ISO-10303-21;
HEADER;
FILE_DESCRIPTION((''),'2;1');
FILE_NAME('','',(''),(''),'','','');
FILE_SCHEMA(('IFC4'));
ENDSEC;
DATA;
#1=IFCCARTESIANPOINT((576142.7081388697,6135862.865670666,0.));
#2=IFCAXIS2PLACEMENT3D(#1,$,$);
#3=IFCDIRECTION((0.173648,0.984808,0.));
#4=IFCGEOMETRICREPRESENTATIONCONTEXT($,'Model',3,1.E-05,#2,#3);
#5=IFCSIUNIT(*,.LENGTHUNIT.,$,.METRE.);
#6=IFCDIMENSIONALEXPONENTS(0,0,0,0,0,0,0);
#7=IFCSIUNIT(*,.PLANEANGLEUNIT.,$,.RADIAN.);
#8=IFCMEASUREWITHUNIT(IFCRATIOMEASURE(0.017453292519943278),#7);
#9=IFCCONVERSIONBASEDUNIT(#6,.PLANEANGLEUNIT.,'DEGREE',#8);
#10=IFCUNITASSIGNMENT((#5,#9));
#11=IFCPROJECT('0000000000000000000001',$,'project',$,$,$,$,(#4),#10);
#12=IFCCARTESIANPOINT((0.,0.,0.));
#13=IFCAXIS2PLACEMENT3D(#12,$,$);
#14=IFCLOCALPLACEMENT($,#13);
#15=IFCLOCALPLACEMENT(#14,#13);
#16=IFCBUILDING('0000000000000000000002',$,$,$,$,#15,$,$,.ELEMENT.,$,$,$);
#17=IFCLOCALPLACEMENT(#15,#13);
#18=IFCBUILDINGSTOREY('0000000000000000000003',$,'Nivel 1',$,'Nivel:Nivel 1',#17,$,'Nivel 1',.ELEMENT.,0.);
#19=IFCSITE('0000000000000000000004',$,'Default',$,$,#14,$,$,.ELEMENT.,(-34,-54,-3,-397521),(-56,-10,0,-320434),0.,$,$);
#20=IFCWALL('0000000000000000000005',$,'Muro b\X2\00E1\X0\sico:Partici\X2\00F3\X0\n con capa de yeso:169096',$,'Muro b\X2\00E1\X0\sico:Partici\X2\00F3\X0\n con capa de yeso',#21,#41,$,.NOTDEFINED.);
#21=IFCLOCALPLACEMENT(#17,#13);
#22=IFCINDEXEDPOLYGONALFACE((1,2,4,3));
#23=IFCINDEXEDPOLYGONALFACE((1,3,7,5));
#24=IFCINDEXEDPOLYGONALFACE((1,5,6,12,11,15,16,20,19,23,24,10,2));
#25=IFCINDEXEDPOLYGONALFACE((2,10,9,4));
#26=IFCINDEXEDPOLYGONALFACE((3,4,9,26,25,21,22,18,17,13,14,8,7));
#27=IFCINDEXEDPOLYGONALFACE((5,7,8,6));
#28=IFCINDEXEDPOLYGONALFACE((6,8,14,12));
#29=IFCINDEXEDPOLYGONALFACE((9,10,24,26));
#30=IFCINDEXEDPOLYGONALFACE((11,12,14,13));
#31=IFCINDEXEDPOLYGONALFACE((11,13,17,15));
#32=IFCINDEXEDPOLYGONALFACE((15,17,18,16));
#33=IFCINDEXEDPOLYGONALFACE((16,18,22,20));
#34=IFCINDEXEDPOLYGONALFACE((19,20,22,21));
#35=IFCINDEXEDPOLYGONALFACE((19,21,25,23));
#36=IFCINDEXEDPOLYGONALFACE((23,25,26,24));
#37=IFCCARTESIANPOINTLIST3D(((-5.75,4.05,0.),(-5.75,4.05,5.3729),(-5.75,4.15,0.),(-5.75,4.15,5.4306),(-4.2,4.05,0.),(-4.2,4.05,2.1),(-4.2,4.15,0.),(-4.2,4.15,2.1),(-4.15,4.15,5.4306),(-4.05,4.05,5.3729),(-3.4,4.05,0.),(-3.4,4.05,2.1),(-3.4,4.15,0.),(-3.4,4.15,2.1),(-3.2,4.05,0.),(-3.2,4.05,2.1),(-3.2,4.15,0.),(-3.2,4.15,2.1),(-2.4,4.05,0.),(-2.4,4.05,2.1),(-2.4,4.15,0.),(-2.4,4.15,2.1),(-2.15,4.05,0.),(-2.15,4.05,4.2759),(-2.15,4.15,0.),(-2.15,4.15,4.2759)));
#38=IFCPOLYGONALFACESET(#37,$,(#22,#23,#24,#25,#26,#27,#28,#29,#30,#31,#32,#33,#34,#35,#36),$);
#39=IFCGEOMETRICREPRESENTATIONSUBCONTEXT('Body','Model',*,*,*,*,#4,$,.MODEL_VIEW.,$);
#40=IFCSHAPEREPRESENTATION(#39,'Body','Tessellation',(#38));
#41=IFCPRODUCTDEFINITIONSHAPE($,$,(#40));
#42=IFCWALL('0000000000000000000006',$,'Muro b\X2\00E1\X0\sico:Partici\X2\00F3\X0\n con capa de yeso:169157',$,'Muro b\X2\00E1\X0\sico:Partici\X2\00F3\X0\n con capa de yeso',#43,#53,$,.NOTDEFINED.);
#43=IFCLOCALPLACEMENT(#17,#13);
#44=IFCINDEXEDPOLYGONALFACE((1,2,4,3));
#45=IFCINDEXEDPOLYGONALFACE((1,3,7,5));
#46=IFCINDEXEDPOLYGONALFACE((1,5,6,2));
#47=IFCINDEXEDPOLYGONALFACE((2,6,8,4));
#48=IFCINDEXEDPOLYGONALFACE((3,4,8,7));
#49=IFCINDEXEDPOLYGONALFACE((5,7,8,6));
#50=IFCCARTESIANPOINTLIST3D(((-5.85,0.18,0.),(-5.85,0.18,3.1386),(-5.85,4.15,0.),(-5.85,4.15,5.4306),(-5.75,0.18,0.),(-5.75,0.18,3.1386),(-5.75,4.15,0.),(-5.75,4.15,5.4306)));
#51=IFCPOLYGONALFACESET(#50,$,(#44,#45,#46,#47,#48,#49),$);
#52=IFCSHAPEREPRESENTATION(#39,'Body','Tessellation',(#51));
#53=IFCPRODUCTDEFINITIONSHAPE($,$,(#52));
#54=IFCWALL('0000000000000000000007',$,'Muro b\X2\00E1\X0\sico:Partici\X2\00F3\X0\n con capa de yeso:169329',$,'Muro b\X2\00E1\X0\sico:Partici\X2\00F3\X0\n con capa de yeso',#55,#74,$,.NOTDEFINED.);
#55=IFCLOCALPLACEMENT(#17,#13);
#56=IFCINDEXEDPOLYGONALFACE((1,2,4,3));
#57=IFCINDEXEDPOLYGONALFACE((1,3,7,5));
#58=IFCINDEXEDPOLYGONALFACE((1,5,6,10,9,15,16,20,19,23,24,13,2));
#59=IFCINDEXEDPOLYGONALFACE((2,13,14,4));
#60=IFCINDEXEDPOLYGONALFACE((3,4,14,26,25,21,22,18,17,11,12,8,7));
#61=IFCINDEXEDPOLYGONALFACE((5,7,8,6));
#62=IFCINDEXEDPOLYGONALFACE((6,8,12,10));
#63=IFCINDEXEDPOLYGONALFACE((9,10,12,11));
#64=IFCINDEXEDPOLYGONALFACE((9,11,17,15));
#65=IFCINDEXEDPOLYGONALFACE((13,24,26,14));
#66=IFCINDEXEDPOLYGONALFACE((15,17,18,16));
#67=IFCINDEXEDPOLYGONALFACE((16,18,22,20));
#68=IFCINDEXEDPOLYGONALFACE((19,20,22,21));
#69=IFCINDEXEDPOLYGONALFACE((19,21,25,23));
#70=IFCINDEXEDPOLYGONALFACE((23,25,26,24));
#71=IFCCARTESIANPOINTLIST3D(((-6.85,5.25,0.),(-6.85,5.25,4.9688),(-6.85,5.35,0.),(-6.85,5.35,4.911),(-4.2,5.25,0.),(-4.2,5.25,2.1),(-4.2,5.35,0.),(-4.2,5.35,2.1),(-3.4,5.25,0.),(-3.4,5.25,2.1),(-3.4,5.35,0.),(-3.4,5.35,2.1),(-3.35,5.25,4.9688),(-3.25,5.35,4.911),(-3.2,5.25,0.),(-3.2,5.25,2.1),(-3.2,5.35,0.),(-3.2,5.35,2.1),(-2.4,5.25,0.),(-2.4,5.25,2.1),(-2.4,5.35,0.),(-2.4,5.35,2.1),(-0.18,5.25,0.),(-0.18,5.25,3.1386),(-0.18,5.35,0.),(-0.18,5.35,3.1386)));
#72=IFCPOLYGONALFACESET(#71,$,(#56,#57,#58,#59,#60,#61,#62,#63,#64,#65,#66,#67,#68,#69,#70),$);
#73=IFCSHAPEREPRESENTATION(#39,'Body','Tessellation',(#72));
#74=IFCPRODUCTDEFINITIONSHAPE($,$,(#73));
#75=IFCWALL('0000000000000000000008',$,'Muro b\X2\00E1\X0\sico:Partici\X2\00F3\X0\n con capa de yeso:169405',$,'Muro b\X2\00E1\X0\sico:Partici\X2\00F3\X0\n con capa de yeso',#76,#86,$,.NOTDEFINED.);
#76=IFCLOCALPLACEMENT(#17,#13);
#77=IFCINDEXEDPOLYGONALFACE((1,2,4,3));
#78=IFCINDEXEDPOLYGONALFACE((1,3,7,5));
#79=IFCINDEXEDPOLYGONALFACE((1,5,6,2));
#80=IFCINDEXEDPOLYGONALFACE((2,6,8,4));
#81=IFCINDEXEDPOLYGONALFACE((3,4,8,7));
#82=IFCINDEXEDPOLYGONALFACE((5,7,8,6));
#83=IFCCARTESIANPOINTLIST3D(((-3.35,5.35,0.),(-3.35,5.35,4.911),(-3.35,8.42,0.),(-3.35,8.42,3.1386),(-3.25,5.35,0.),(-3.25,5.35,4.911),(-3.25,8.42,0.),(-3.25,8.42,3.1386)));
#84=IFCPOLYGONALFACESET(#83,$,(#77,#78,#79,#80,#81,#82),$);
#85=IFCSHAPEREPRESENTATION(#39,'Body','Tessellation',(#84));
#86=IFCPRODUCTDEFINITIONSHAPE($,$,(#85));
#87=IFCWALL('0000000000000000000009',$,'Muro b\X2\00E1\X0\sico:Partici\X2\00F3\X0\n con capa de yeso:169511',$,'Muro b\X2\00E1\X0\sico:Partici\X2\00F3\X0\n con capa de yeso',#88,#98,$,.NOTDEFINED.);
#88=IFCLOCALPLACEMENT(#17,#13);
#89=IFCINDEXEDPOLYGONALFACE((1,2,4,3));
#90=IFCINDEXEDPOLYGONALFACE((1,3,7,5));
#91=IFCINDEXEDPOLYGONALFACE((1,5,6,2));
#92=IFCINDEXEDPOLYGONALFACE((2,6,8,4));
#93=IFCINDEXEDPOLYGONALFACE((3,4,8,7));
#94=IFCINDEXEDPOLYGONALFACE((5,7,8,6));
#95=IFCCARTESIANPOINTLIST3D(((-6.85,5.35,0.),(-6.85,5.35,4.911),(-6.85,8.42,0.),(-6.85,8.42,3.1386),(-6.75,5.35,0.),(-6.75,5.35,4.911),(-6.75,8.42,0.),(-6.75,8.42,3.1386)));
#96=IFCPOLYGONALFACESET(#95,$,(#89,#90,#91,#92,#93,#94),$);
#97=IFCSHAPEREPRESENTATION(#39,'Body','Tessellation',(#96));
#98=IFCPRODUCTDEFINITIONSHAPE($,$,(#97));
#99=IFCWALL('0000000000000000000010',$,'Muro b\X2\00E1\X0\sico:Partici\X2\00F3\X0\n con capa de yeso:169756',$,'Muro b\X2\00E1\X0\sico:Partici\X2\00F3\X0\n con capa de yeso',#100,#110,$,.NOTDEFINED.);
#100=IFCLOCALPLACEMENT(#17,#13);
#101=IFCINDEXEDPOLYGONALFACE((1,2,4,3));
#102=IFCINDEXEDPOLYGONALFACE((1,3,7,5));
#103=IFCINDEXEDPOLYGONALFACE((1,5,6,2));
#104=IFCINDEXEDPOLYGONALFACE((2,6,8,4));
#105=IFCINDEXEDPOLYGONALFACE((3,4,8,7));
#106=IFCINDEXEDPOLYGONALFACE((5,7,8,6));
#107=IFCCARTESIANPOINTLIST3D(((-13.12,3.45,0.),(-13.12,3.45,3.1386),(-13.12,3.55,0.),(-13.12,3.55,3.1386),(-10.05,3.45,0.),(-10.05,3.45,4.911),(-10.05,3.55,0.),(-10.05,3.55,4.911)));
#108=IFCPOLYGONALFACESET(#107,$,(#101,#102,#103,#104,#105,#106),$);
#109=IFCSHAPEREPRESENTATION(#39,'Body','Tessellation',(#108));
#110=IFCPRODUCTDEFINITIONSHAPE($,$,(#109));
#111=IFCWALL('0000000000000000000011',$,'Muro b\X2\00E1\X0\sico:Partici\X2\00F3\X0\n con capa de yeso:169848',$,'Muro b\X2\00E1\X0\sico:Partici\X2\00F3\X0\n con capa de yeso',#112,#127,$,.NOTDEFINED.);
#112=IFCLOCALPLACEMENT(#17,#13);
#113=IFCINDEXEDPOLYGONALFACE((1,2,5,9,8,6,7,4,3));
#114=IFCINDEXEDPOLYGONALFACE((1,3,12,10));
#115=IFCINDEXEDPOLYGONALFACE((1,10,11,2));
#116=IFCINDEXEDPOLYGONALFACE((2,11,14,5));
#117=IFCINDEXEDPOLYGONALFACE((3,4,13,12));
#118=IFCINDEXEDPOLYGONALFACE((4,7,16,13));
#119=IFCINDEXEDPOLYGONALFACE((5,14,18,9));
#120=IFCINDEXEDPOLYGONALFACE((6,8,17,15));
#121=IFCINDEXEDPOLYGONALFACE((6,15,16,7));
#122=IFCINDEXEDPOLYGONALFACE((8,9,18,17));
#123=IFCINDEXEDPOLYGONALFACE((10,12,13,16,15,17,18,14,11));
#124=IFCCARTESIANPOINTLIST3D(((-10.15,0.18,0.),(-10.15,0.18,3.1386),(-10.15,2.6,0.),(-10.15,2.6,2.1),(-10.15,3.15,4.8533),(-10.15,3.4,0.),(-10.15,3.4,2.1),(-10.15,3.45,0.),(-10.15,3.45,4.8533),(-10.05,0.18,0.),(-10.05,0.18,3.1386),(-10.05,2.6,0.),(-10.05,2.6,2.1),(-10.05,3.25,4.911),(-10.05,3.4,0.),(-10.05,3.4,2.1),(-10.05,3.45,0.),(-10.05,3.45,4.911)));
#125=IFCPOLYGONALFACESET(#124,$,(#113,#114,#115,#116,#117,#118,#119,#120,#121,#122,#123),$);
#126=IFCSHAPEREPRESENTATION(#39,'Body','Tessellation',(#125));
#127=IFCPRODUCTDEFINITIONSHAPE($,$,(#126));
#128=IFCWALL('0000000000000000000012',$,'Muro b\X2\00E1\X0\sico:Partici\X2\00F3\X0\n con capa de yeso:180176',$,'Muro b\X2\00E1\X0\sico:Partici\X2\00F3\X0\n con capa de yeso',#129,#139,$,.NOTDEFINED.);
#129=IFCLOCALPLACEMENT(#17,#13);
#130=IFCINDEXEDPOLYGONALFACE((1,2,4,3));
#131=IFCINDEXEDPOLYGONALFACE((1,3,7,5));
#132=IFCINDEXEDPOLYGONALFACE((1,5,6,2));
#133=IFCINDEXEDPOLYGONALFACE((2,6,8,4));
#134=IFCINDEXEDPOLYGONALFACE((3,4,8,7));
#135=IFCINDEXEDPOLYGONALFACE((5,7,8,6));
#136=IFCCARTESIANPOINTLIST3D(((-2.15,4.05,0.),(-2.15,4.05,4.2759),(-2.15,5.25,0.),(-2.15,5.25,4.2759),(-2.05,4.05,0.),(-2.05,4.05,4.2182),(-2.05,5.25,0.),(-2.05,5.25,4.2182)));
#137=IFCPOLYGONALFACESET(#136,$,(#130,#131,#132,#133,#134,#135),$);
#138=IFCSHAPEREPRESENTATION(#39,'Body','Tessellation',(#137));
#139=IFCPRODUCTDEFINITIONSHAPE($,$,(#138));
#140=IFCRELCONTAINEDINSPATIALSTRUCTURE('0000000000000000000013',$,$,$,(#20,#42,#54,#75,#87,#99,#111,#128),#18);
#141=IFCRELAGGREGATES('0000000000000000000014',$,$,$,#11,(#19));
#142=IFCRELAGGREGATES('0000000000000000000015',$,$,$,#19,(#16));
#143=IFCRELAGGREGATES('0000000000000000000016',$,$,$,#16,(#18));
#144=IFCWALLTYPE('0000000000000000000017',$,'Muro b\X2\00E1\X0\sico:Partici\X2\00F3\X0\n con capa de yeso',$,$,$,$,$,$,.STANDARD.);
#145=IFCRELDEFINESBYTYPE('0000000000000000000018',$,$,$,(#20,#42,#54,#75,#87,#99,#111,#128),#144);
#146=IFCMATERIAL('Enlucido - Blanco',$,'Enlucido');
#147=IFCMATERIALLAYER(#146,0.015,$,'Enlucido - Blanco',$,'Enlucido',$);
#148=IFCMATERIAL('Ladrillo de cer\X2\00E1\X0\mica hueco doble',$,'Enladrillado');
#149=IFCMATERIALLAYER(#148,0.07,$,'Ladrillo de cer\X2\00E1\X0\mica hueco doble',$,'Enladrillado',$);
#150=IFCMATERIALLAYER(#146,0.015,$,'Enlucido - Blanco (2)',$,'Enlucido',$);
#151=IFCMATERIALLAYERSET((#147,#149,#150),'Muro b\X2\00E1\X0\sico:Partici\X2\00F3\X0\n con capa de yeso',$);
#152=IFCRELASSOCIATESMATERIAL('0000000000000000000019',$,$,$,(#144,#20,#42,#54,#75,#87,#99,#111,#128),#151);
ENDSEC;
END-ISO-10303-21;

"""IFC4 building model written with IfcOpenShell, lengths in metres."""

from ifc_helpers import new_model, entity, si_unit, converted_unit, direction, frame, frame_2d, origin, place, context, subcontext, project, spatial, polyline, rectangle, extrude, clip, bounded_halfspace, material, layer, layer_set, layer_usage, type_object, element, save


model = new_model("IFC4")

# Units and contexts
model_context = context("Model", 3, precision=1e-05, world=frame((576142.7081388697, 6135862.865670666, 0.0)), true_north=direction((0.173648, 0.984808, 0.0)))
body_context = subcontext(model_context, "Body", "Model", "MODEL_VIEW")
ifc_project = project(units=[si_unit("LENGTHUNIT", "METRE"), converted_unit("PLANEANGLEUNIT", "DEGREE", entity("IfcRatioMeasure", 0.017453292519943278), si_unit("PLANEANGLEUNIT", "RADIAN"), dimensions=[0, 0, 0, 0, 0, 0, 0])], contexts=[model_context])

# Site, building, storey
site_placement = place(None, origin())
site = spatial("IfcSite", under=ifc_project, at=site_placement, Name="Default", CompositionType="ELEMENT", RefLatitude=(-34, -54, -3, -397521), RefLongitude=(-56, -10, 0, -320434), RefElevation=0.0)
building_placement = place(site_placement, origin())
building = spatial("IfcBuilding", under=site, at=building_placement, CompositionType="ELEMENT")
storey_placement = place(building_placement, origin())
storey = spatial("IfcBuildingStorey", under=building, at=storey_placement, Name="Nivel 1", ObjectType="Nivel:Nivel 1", LongName="Nivel 1", CompositionType="ELEMENT", Elevation=0.0)

# Shared definitions
ifc_material_1 = material(Name="Enlucido - Blanco", Category="Enlucido")
ifc_layer_1 = layer(ifc_material_1, 0.015, Name="Enlucido - Blanco", Category="Enlucido")
ifc_material_2 = material(Name="Ladrillo de cerámica hueco doble", Category="Enladrillado")
ifc_layer_2 = layer(ifc_material_2, 0.07, Name="Ladrillo de cerámica hueco doble", Category="Enladrillado")
ifc_layer_3 = layer(ifc_material_1, 0.015, Name="Enlucido - Blanco (2)", Category="Enlucido")
ifc_layer_set_1 = layer_set([ifc_layer_1, ifc_layer_2, ifc_layer_3], Name="Muro básico:Partición con capa de yeso")
ifc_layer_usage_1 = layer_usage(ifc_layer_set_1, "AXIS2", "NEGATIVE", 0.05)
wall_type_1 = type_object("IfcWallType", Name="Muro básico:Partición con capa de yeso", PredefinedType="STANDARD", material=ifc_layer_set_1)

# Wall, openings
wall_1_placement = place(storey_placement, frame((-5.75, 4.1, 0.0)))
wall_1 = element("IfcWall", 1, at=wall_1_placement, inside=storey, type_object=wall_type_1, material=ifc_layer_usage_1, Name="Muro básico:Partición con capa de yeso:169096", ObjectType="Muro básico:Partición con capa de yeso", PredefinedType="NOTDEFINED", context=body_context, shape_type="Clipping", body=[
    clip(clip(extrude(rectangle(XDim=3.6, YDim=0.1, at=frame_2d((1.8, 0.0), x_axis=(-1.0, 0.0))), origin(), (0.0, 0.0, 1.0), 5.4306), bounded_halfspace(frame((3.6, -0.05, 4.2759), z_axis=(0.5, 0.0, 0.866025), x_axis=(0.0, 1.0, 0.0)), False, frame((3.6, -0.05, 4.2759)), polyline([(0.0, 0.0), (0.0, 0.1), (-2.0, 0.1), (-1.9, 0.0), (-1.2, 0.0), (-1.1, 0.0), (0.0, 0.0)]))), bounded_halfspace(frame((0.0, 0.05, 5.4306), z_axis=(0.0, -0.5, 0.866025), x_axis=(1.0, 0.0, 0.0)), False, frame((0.0, 0.05, 5.4306)), polyline([(0.0, 0.0), (0.0, -0.1), (1.7, -0.1), (1.6, 0.0), (0.0, 0.0)]))),
])
opening_1_placement = place(wall_1_placement, frame((3.35, 0.05, 0.0)))
element("IfcOpeningElement", 2, at=opening_1_placement, cuts=wall_1, PredefinedType="OPENING", context=body_context, shape_type="SweptSolid", body=[
    extrude(rectangle(XDim=2.1, YDim=0.8, at=frame_2d((1.05, 0.4), x_axis=(1.0, 0.0))), frame((0.0, 0.0, 0.0), z_axis=(0.0, -1.0, 0.0), x_axis=(0.0, 0.0, 1.0)), (0.0, 0.0, 1.0), 0.1),
])
opening_2_placement = place(wall_1_placement, frame((2.35, 0.05, 0.0)))
element("IfcOpeningElement", 3, at=opening_2_placement, cuts=wall_1, PredefinedType="OPENING", context=body_context, shape_type="SweptSolid", body=[
    extrude(rectangle(XDim=2.1, YDim=0.8, at=frame_2d((1.05, 0.4), x_axis=(1.0, 0.0))), frame((0.0, 0.0, 0.0), z_axis=(0.0, -1.0, 0.0), x_axis=(0.0, 0.0, 1.0)), (0.0, 0.0, 1.0), 0.1),
])

# Wall
wall_2_placement = place(storey_placement, frame((-5.8, 0.18, 0.0), z_axis=(0.0, 0.0, 1.0), x_axis=(0.0, 1.0, 0.0)))
element("IfcWall", 4, at=wall_2_placement, inside=storey, type_object=wall_type_1, material=ifc_layer_usage_1, Name="Muro básico:Partición con capa de yeso:169157", ObjectType="Muro básico:Partición con capa de yeso", PredefinedType="NOTDEFINED", context=body_context, shape_type="Clipping", body=[
    clip(extrude(rectangle(XDim=3.97, YDim=0.1, at=frame_2d((1.985, 0.0), x_axis=(-1.0, 0.0))), origin(), (0.0, 0.0, 1.0), 5.4306), bounded_halfspace(frame((0.0, -0.05, 3.1386), z_axis=(-0.5, 0.0, 0.866025), x_axis=(0.0, -1.0, 0.0)), False, frame((0.0, -0.05, 3.1386)), polyline([(0.0, 0.0), (3.87, 0.0), (3.97, 0.0), (3.97, 0.1), (0.0, 0.1), (0.0, 0.0)]))),
])

# Wall, openings
wall_3_placement = place(storey_placement, frame((-0.18, 5.3, 0.0), z_axis=(0.0, 0.0, 1.0), x_axis=(-1.0, 0.0, 0.0)))
wall_3 = element("IfcWall", 5, at=wall_3_placement, inside=storey, type_object=wall_type_1, material=ifc_layer_usage_1, Name="Muro básico:Partición con capa de yeso:169329", ObjectType="Muro básico:Partición con capa de yeso", PredefinedType="NOTDEFINED", context=body_context, shape_type="Clipping", body=[
    clip(clip(extrude(rectangle(XDim=6.67, YDim=0.1, at=frame_2d((3.335, 0.0), x_axis=(-1.0, 0.0))), origin(), (0.0, 0.0, 1.0), 4.9688), bounded_halfspace(frame((6.67, -0.05, 4.911), z_axis=(0.0, -0.5, 0.866025), x_axis=(1.0, 0.0, 0.0)), False, frame((6.67, -0.05, 4.911)), polyline([(0.0, 0.0), (0.0, 0.1), (-3.5, 0.1), (-3.6, 0.0), (-3.5, 0.0), (-0.1, 0.0), (0.0, 0.0)]))), bounded_halfspace(frame((0.0, 0.05, 3.1386), z_axis=(-0.5, 0.0, 0.866025), x_axis=(0.0, -1.0, 0.0)), False, frame((0.0, 0.05, 3.1386)), polyline([(0.0, 0.0), (0.0, -0.1), (3.07, -0.1), (3.17, 0.0), (1.97, 0.0), (1.87, 0.0), (0.0, 0.0)]))),
])
opening_3_placement = place(wall_3_placement, frame((4.02, 0.05, 0.0)))
element("IfcOpeningElement", 6, at=opening_3_placement, cuts=wall_3, PredefinedType="OPENING", context=body_context, shape_type="SweptSolid", body=[
    extrude(rectangle(XDim=2.1, YDim=0.8, at=frame_2d((1.05, 0.4), x_axis=(1.0, 0.0))), frame((0.0, 0.0, 0.0), z_axis=(0.0, -1.0, 0.0), x_axis=(0.0, 0.0, 1.0)), (0.0, 0.0, 1.0), 0.1),
])
opening_4_placement = place(wall_3_placement, frame((3.02, 0.05, 0.0)))
element("IfcOpeningElement", 7, at=opening_4_placement, cuts=wall_3, PredefinedType="OPENING", context=body_context, shape_type="SweptSolid", body=[
    extrude(rectangle(XDim=2.1, YDim=0.8, at=frame_2d((1.05, 0.4), x_axis=(1.0, 0.0))), frame((0.0, 0.0, 0.0), z_axis=(0.0, -1.0, 0.0), x_axis=(0.0, 0.0, 1.0)), (0.0, 0.0, 1.0), 0.1),
])

# Walls
wall_4_placement = place(storey_placement, frame((-3.3, 5.35, 0.0), z_axis=(0.0, 0.0, 1.0), x_axis=(0.0, 1.0, 0.0)))
element("IfcWall", 8, at=wall_4_placement, inside=storey, type_object=wall_type_1, material=ifc_layer_usage_1, Name="Muro básico:Partición con capa de yeso:169405", ObjectType="Muro básico:Partición con capa de yeso", PredefinedType="NOTDEFINED", context=body_context, shape_type="Clipping", body=[
    clip(extrude(rectangle(XDim=3.07, YDim=0.1, at=frame_2d((1.535, 0.0), x_axis=(-1.0, 0.0))), origin(), (0.0, 0.0, 1.0), 4.911), bounded_halfspace(frame((0.0, -0.05, 4.911), z_axis=(0.5, 0.0, 0.866025), x_axis=(0.0, 1.0, 0.0)), False, frame((0.0, -0.05, 4.911)), polyline([(0.0, 0.0), (3.07, 0.0), (3.07, 0.1), (0.0, 0.1), (0.0, 0.0)]))),
])
wall_5_placement = place(storey_placement, frame((-6.8, 5.35, 0.0), z_axis=(0.0, 0.0, 1.0), x_axis=(0.0, 1.0, 0.0)))
element("IfcWall", 9, at=wall_5_placement, inside=storey, type_object=wall_type_1, material=ifc_layer_usage_1, Name="Muro básico:Partición con capa de yeso:169511", ObjectType="Muro básico:Partición con capa de yeso", PredefinedType="NOTDEFINED", context=body_context, shape_type="Clipping", body=[
    clip(extrude(rectangle(XDim=3.07, YDim=0.1, at=frame_2d((1.535, 0.0), x_axis=(-1.0, 0.0))), origin(), (0.0, 0.0, 1.0), 4.911), bounded_halfspace(frame((0.0, -0.05, 4.911), z_axis=(0.5, 0.0, 0.866025), x_axis=(0.0, 1.0, 0.0)), False, frame((0.0, -0.05, 4.911)), polyline([(0.0, 0.0), (3.07, 0.0), (3.07, 0.1), (0.0, 0.1), (0.0, 0.0)]))),
])
wall_6_placement = place(storey_placement, frame((-13.12, 3.5, 0.0)))
element("IfcWall", 10, at=wall_6_placement, inside=storey, type_object=wall_type_1, material=ifc_layer_usage_1, Name="Muro básico:Partición con capa de yeso:169756", ObjectType="Muro básico:Partición con capa de yeso", PredefinedType="NOTDEFINED", context=body_context, shape_type="Clipping", body=[
    clip(extrude(rectangle(XDim=3.07, YDim=0.1, at=frame_2d((1.535, 0.0), x_axis=(-1.0, 0.0))), origin(), (0.0, 0.0, 1.0), 4.911), bounded_halfspace(frame((0.0, -0.05, 3.1386), z_axis=(-0.5, 0.0, 0.866025), x_axis=(0.0, -1.0, 0.0)), False, frame((0.0, -0.05, 3.1386)), polyline([(0.0, 0.0), (2.97, 0.0), (3.07, 0.0), (3.07, 0.1), (0.0, 0.1), (0.0, 0.0)]))),
])

# Wall, opening
wall_7_placement = place(storey_placement, frame((-10.1, 3.45, 0.0), z_axis=(0.0, 0.0, 1.0), x_axis=(0.0, -1.0, 0.0)))
wall_7 = element("IfcWall", 11, at=wall_7_placement, inside=storey, type_object=wall_type_1, material=ifc_layer_usage_1, Name="Muro básico:Partición con capa de yeso:169848", ObjectType="Muro básico:Partición con capa de yeso", PredefinedType="NOTDEFINED", context=body_context, shape_type="Clipping", body=[
    clip(clip(extrude(rectangle(XDim=0.1, YDim=3.27, at=frame_2d((1.635, 0.0), x_axis=(0.0, 1.0))), origin(), (0.0, 0.0, 1.0), 4.911), bounded_halfspace(frame((0.0, 0.05, 4.911), z_axis=(0.0, -0.5, 0.866025), x_axis=(1.0, 0.0, 0.0)), False, frame((0.0, 0.05, 4.911)), polyline([(0.0, 0.0), (0.0, -0.1), (0.3, -0.1), (0.2, 0.0), (0.0, 0.0)]))), bounded_halfspace(frame((3.27, -0.05, 3.1386), z_axis=(0.5, 0.0, 0.866025), x_axis=(0.0, 1.0, 0.0)), False, frame((3.27, -0.05, 3.1386)), polyline([(0.0, 0.0), (0.0, 0.1), (-3.07, 0.1), (-2.97, 0.0), (0.0, 0.0)]))),
])
opening_5_placement = place(wall_7_placement, frame((0.85, 0.05, 0.0)))
element("IfcOpeningElement", 12, at=opening_5_placement, cuts=wall_7, PredefinedType="OPENING", context=body_context, shape_type="SweptSolid", body=[
    extrude(rectangle(XDim=2.1, YDim=0.8, at=frame_2d((1.05, 0.4), x_axis=(1.0, 0.0))), frame((0.0, 0.0, 0.0), z_axis=(0.0, -1.0, 0.0), x_axis=(0.0, 0.0, 1.0)), (0.0, 0.0, 1.0), 0.1),
])

# Wall
wall_8_placement = place(storey_placement, frame((-2.1, 4.05, 0.0), z_axis=(0.0, 0.0, 1.0), x_axis=(0.0, 1.0, 0.0)))
element("IfcWall", 13, at=wall_8_placement, inside=storey, type_object=wall_type_1, material=ifc_layer_usage_1, Name="Muro básico:Partición con capa de yeso:180176", ObjectType="Muro básico:Partición con capa de yeso", PredefinedType="NOTDEFINED", context=body_context, shape_type="Clipping", body=[
    clip(extrude(rectangle(XDim=1.2, YDim=0.1, at=frame_2d((0.6, 0.0), x_axis=(-1.0, 0.0))), origin(), (0.0, 0.0, 1.0), 4.2759), bounded_halfspace(frame((0.0, -0.05, 4.2182), z_axis=(0.0, -0.5, 0.866025), x_axis=(1.0, 0.0, 0.0)), False, frame((0.0, -0.05, 4.2182)), polyline([(0.0, 0.0), (1.2, 0.0), (1.2, 0.1), (0.1, 0.1), (0.0, 0.1), (0.0, 0.0)]))),
])

save(model, "model.ifc")
